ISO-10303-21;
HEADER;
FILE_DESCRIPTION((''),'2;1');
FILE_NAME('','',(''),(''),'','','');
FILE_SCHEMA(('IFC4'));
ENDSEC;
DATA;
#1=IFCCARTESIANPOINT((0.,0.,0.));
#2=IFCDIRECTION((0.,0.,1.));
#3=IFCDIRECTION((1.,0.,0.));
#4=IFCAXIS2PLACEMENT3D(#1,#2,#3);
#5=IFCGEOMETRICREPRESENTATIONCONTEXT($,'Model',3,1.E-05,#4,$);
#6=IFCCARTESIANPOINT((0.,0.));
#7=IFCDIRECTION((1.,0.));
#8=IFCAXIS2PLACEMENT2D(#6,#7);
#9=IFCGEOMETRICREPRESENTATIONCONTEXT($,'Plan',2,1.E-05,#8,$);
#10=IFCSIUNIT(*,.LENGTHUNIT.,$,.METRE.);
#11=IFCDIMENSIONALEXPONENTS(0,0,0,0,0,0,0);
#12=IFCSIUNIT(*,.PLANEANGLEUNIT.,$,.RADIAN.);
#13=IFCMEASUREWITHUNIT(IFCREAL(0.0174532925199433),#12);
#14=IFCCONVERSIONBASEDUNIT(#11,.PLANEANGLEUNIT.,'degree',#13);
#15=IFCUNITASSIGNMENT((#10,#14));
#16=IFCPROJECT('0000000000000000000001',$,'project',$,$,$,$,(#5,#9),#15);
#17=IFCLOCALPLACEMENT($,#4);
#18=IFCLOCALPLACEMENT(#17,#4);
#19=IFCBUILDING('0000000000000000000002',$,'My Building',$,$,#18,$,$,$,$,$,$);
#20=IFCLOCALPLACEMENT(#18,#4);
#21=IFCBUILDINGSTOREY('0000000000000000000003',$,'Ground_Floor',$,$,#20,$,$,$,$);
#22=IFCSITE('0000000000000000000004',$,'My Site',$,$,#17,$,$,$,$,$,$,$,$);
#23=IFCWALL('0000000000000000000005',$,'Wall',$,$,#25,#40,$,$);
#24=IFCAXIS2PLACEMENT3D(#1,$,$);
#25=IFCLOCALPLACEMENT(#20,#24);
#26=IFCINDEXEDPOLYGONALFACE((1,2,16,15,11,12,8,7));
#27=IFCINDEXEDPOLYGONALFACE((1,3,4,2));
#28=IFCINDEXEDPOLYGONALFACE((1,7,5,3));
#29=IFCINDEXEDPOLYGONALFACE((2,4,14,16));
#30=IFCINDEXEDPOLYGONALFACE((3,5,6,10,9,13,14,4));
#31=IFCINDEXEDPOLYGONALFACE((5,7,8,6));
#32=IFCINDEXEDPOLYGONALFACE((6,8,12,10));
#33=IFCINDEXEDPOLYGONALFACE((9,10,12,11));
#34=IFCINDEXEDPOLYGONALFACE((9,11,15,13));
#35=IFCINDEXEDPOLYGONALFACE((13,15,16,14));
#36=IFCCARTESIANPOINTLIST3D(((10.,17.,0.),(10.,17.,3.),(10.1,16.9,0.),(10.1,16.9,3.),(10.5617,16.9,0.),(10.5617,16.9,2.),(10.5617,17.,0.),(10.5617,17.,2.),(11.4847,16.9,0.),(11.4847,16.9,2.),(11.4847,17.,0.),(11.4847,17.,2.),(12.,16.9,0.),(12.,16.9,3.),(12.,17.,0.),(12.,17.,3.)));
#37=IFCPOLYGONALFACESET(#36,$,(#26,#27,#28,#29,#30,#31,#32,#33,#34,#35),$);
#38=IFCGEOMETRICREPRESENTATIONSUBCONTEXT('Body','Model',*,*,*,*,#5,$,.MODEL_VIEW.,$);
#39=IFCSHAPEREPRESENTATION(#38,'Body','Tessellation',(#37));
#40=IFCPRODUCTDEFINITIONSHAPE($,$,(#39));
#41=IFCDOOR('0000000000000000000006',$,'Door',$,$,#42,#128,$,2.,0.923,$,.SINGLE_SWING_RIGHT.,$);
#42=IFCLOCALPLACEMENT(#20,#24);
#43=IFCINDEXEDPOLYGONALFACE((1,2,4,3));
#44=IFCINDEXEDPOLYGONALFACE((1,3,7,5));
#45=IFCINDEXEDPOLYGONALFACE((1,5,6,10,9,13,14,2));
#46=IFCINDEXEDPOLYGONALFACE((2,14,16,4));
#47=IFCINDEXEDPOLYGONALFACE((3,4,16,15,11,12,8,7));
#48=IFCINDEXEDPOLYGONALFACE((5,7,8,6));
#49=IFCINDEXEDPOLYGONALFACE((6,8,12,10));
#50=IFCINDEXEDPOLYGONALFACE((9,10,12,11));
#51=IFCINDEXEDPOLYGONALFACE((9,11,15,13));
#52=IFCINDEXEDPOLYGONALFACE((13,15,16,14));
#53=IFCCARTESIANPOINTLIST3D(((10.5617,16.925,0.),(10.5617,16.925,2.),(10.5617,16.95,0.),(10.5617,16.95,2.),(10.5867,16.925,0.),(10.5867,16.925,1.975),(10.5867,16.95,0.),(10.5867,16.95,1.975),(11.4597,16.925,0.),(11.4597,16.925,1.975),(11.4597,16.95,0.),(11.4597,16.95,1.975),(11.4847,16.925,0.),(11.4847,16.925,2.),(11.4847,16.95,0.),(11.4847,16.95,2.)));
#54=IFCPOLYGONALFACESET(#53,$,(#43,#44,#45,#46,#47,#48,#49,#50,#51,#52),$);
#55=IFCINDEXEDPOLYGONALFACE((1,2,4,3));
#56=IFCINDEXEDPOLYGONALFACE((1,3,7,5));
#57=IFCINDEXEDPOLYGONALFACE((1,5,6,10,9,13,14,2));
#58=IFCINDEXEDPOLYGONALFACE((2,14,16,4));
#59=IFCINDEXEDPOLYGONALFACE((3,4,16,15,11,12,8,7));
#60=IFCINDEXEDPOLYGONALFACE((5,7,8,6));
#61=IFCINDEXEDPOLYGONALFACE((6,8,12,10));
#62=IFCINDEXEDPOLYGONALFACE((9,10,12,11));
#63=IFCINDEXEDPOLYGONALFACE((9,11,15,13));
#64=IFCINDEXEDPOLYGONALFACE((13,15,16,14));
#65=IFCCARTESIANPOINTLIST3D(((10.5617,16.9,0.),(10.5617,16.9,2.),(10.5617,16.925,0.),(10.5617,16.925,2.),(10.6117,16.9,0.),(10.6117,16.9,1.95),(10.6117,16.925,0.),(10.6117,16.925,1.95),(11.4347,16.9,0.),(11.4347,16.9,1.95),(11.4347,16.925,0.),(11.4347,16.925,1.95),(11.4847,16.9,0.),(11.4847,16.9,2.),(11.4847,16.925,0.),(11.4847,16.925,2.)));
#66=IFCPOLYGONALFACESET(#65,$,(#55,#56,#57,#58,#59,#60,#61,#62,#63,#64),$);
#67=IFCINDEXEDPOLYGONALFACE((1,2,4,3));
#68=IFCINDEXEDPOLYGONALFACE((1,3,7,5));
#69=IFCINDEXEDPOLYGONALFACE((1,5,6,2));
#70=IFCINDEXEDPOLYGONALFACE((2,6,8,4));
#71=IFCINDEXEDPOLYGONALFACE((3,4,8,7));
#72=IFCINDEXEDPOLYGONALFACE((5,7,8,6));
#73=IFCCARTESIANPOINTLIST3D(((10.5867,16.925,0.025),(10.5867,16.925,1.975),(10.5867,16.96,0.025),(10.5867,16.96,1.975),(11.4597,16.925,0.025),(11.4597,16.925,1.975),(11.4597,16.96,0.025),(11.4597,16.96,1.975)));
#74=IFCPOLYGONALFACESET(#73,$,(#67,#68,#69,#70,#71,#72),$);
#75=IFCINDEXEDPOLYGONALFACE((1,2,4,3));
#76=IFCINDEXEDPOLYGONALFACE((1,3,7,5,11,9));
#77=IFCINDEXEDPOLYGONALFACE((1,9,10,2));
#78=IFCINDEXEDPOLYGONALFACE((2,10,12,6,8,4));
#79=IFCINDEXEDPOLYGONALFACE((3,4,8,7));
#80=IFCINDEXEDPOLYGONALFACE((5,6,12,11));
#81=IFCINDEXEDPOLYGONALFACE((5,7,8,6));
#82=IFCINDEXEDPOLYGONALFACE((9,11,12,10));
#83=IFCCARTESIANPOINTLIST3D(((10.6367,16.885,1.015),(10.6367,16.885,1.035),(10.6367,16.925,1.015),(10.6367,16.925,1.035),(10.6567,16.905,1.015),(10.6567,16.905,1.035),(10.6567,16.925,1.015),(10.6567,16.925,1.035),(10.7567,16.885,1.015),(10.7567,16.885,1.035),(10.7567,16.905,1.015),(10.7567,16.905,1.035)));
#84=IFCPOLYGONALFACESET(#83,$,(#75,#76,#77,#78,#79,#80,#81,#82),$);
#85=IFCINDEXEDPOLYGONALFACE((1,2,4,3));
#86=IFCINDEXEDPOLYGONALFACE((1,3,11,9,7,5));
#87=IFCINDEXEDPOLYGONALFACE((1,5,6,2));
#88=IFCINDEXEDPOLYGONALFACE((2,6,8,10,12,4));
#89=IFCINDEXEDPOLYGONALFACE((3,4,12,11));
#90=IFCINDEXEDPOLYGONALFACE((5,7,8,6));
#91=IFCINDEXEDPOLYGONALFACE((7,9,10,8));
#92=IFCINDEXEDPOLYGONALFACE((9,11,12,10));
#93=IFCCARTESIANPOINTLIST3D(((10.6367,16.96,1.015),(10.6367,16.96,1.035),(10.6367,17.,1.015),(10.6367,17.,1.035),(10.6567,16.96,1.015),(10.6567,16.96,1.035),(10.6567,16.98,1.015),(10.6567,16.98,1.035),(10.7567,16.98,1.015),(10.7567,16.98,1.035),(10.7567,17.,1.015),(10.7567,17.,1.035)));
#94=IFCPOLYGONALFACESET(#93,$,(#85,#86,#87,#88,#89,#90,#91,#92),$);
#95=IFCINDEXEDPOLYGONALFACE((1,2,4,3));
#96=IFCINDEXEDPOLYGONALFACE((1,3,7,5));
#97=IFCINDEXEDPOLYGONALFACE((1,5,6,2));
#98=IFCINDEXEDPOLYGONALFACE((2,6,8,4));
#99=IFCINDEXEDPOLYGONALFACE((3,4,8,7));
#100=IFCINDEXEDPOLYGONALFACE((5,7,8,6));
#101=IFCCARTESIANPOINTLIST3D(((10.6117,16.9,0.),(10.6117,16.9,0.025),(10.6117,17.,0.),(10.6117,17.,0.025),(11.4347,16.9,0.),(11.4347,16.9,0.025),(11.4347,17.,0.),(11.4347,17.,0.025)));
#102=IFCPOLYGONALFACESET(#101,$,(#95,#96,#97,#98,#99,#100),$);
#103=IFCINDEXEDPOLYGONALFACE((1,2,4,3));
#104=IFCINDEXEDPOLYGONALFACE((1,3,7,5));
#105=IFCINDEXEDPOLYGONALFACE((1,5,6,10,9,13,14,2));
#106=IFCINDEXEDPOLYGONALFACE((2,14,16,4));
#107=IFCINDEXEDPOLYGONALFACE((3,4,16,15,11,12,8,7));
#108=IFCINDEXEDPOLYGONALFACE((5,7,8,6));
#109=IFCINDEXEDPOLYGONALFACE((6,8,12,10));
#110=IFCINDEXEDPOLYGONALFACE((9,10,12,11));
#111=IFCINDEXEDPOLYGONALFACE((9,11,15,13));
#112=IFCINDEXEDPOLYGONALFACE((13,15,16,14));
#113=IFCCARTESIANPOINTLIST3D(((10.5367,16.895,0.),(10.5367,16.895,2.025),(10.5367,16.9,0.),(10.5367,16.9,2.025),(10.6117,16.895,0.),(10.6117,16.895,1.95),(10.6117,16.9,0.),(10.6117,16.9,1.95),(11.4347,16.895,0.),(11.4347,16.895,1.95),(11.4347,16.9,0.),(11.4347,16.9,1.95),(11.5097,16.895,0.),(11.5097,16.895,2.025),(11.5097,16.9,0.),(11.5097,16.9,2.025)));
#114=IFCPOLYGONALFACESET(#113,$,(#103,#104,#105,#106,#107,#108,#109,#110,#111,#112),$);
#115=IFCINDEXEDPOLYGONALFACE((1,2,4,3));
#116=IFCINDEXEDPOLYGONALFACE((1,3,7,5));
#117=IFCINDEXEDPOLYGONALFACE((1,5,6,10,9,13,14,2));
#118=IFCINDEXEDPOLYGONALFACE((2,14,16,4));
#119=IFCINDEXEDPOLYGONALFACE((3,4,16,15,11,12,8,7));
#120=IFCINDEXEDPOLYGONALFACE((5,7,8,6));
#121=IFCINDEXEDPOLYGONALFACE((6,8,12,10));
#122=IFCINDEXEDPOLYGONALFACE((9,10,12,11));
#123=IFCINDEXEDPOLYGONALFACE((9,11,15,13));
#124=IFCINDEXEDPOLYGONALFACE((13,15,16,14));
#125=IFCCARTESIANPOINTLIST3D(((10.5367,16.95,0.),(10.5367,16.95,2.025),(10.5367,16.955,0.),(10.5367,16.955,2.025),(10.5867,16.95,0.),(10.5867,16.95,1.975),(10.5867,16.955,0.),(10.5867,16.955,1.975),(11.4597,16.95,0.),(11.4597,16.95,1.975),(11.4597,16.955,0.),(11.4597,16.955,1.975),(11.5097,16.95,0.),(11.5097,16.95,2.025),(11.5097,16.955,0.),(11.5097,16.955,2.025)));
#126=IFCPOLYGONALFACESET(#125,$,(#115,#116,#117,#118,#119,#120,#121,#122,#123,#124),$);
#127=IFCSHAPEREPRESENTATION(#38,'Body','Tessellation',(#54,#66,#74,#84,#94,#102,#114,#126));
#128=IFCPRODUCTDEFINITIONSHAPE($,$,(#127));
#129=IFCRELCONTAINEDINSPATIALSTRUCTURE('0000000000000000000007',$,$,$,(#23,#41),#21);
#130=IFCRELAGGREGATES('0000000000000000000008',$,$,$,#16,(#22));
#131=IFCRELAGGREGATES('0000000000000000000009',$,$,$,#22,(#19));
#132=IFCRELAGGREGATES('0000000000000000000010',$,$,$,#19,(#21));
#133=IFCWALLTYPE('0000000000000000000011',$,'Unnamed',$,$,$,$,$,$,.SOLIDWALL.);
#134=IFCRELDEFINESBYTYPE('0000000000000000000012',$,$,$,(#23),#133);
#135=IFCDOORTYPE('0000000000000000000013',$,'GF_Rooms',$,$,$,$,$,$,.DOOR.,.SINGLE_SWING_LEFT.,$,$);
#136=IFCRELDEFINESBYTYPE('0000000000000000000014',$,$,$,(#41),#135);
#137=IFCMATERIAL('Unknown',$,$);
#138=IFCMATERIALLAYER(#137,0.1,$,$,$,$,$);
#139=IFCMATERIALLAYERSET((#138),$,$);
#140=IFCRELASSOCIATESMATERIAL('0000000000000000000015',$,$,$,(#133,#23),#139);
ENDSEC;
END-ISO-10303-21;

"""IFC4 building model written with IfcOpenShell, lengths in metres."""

from ifc_helpers import new_model, entity, si_unit, converted_unit, frame, origin_with_axes, origin_2d_with_axis, place, context, subcontext, project, spatial, line, indexed_curve, outline, extrude, shape, source, transform, mapped, material, layer, layer_set, layer_usage, type_object, type_shapes, element, fill, save


model = new_model("IFC4")

# Units and contexts
model_context = context("Model", 3, precision=1e-05, world=origin_with_axes())
plan_context = context("Plan", 2, precision=1e-05, world=origin_2d_with_axis())
body_context_1 = subcontext(model_context, "Body", "Model", "MODEL_VIEW")
body_context_2 = subcontext(plan_context, "Body", "Plan", "PLAN_VIEW")
ifc_project = project(units=[si_unit("LENGTHUNIT", "METRE"), converted_unit("PLANEANGLEUNIT", "degree", entity("IfcReal", 0.0174532925199433), si_unit("PLANEANGLEUNIT", "RADIAN"), dimensions=[0, 0, 0, 0, 0, 0, 0])], contexts=[model_context, plan_context])

# Site, building, storey
site_placement = place(None, origin_with_axes())
site = spatial("IfcSite", under=ifc_project, at=site_placement, Name="My Site")
building_placement = place(site_placement, origin_with_axes())
building = spatial("IfcBuilding", under=site, at=building_placement, Name="My Building")
storey_placement = place(building_placement, origin_with_axes())
storey = spatial("IfcBuildingStorey", under=building, at=storey_placement, Name="Ground_Floor")

# Shared definitions
ifc_material = material(Name="Unknown")

# Shared definitions
ifc_layer_1 = layer(ifc_material, 0.1)
ifc_layer_set_1 = layer_set([ifc_layer_1])
wall_type = type_object("IfcWallType", Name="Unnamed", PredefinedType="SOLIDWALL", material=ifc_layer_set_1)
shared_shape_1 = source(origin_with_axes(), body_context_1, "Body", "SweptSolid", [
    extrude(outline(indexed_curve([(0.0, 0.0), (0.923, 0.0), (0.923, 2.0), (0.0, 2.0)], segments=[line(1, 2, 3, 4, 1)])), frame((0.0, -0.6, 0.0), z_axis=(0.0, -1.0, 0.0), x_axis=(1.0, 0.0, 0.0)), (0.0, 0.0, -1.0), 1.2),
])
door_type_1 = type_object("IfcDoorType", Name="GF_Rooms", OperationType="SINGLE_SWING_LEFT", PredefinedType="DOOR")
shared_shape_2 = source(origin_with_axes(), body_context_1, "Body", "SweptSolid", [
    extrude(outline(indexed_curve([(0.0, 0.0), (0.0, 2.0), (0.923, 2.0), (0.923, 0.0), (0.898, 0.0), (0.898, 1.975), (0.025, 1.975), (0.025, 0.0)], segments=[line(1, 2, 3, 4, 5, 6, 7, 8, 1)])), frame((0.0, 0.025, 0.0), z_axis=(0.0, -1.0, 0.0), x_axis=(1.0, 0.0, 0.0)), (0.0, 0.0, -1.0), 0.025),
    extrude(outline(indexed_curve([(0.0, 0.0), (0.0, 2.0), (0.923, 2.0), (0.923, 0.0), (0.873, 0.0), (0.873, 1.95), (0.05, 1.95), (0.05, 0.0)], segments=[line(1, 2, 3, 4, 5, 6, 7, 8, 1)])), frame((0.0, 0.0, 0.0), z_axis=(0.0, -1.0, 0.0), x_axis=(1.0, 0.0, 0.0)), (0.0, 0.0, -1.0), 0.025),
    extrude(outline(indexed_curve([(0.0, 0.0), (0.873, 0.0), (0.873, 0.035), (0.0, 0.035)], segments=[line(1, 2, 3, 4, 1)])), frame((0.025, 0.025, 0.025), z_axis=(0.0, 0.0, 1.0), x_axis=(1.0, 0.0, 0.0)), (0.0, 0.0, 1.0), 1.95),
    extrude(outline(indexed_curve([(0.0, 0.0), (0.0, -0.04), (0.12, -0.04), (0.12, -0.02), (0.02, -0.02), (0.02, 0.0)], segments=[line(1, 2, 3, 4, 5, 6, 1)])), frame((0.075, 0.025, 1.015), z_axis=(0.0, 0.0, 1.0), x_axis=(1.0, 0.0, 0.0)), (0.0, 0.0, 1.0), 0.02),
    extrude(outline(indexed_curve([(0.0, 0.0), (0.0, 0.04), (0.12, 0.04), (0.12, 0.02), (0.02, 0.02), (0.02, 0.0)], segments=[line(1, 2, 3, 4, 5, 6, 1)])), frame((0.075, 0.06, 1.015), z_axis=(0.0, 0.0, 1.0), x_axis=(1.0, 0.0, 0.0)), (0.0, 0.0, 1.0), 0.02),
    extrude(outline(indexed_curve([(0.0, 0.0), (0.823, 0.0), (0.823, 0.1), (0.0, 0.1)], segments=[line(1, 2, 3, 4, 1)])), frame((0.05, 0.0, 0.0), z_axis=(0.0, 0.0, 1.0), x_axis=(1.0, 0.0, 0.0)), (0.0, 0.0, 1.0), 0.025),
    extrude(outline(indexed_curve([(0.0, 0.0), (0.0, 2.025), (0.973, 2.025), (0.973, 0.0), (0.898, 0.0), (0.898, 1.95), (0.075, 1.95), (0.075, 0.0)], segments=[line(1, 2, 3, 4, 5, 6, 7, 8, 1)])), frame((-0.025, -0.005, 0.0), z_axis=(0.0, -1.0, 0.0), x_axis=(1.0, 0.0, 0.0)), (0.0, 0.0, -1.0), 0.005),
    extrude(outline(indexed_curve([(0.0, 0.0), (0.0, 2.025), (0.973, 2.025), (0.973, 0.0), (0.923, 0.0), (0.923, 1.975), (0.05, 1.975), (0.05, 0.0)], segments=[line(1, 2, 3, 4, 5, 6, 7, 8, 1)])), frame((-0.025, 0.05, 0.0), z_axis=(0.0, -1.0, 0.0), x_axis=(1.0, 0.0, 0.0)), (0.0, 0.0, -1.0), 0.005),
])
shared_shape_3 = source(origin_with_axes(), body_context_2, "Body", "Curve2D", [
    entity("IfcIndexedPolyCurve", entity("IfcCartesianPointList2D", [[0.0, 0.0], [0.0, 0.05], [0.025, 0.05], [0.025, 0.025], [0.05, 0.025], [0.05, 0.0]]), [entity("IfcLineIndex", [1, 2, 3, 4, 5, 6, 1])]),
    entity("IfcIndexedPolyCurve", entity("IfcCartesianPointList2D", [[0.923, 0.0], [0.923, 0.05], [0.898, 0.05], [0.898, 0.025], [0.873, 0.025], [0.873, 0.0]]), [entity("IfcLineIndex", [1, 2, 3, 4, 5, 6, 1])]),
    entity("IfcTrimmedCurve", entity("IfcEllipse", entity("IfcAxis2Placement2D", entity("IfcCartesianPoint", [0.863, 0.05]), entity("IfcDirection", [1.0, 0.0])), 0.838, 0.873), [entity("IfcCartesianPoint", [0.863, 0.923])], [entity("IfcCartesianPoint", [0.025, 0.05])], True, "CARTESIAN"),
    entity("IfcIndexedPolyCurve", entity("IfcCartesianPointList2D", [[0.898, 0.05], [0.863, 0.05], [0.863, 0.923], [0.898, 0.923]]), [entity("IfcLineIndex", [1, 2, 3, 4, 1])]),
])
type_shapes(door_type_1, [shared_shape_2, shared_shape_3])

# Wall, opening, door
ifc_layer_usage_1 = layer_usage(ifc_layer_set_1, "AXIS2", "POSITIVE", 0.0)
wall_1_placement = place(storey_placement, frame((12.0, 17.0, 0.0), z_axis=(0.0, 0.0, 1.0), x_axis=(-1.0, 0.0, 0.0)))
wall_1 = element("IfcWall", 1, at=wall_1_placement, inside=storey, type_object=wall_type, material=ifc_layer_usage_1, Name="Wall", context=body_context_1, shape_type="SweptSolid", body=[
    extrude(outline(indexed_curve([(0.0, 0.0), (0.0, 0.1), (1.9, 0.1), (2.0, 0.0)], segments=[line(1, 2, 3, 4, 1)])), origin_with_axes(), (0.0, 0.0, 1.0), 3.0),
])
opening_1_placement = place(wall_1_placement, frame((1.4383, 0.1, 0.0), z_axis=(0.0, 0.0, 1.0), x_axis=(-1.0, 0.0, 0.0)))
opening_1 = element("IfcOpeningElement", 2, at=opening_1_placement, cuts=wall_1, PredefinedType="OPENING", context=body_context_1, shape_type="MappedRepresentation", body=[
    mapped(shared_shape_1, transform((0.0, 0.0, 0.0), x_axis=(1.0, 0.0, 0.0), y_axis=(0.0, 1.0, 0.0), z_axis=(0.0, 0.0, 1.0), scale=1.0)),
])
door_1_placement = place(opening_1_placement, frame((0.0, 0.0, 0.0), z_axis=(0.0, 0.0, 1.0), x_axis=(1.0, 0.0, 0.0)))
door_1 = element("IfcDoor", 3, at=door_1_placement, inside=storey, type_object=door_type_1, Name="Door", OperationType="SINGLE_SWING_RIGHT", OverallHeight=2.0, OverallWidth=0.923, shapes=[
    shape(body_context_1, "Body", "MappedRepresentation", [mapped(shared_shape_2, transform((0.0, 0.0, 0.0), x_axis=(1.0, 0.0, 0.0), y_axis=(0.0, 1.0, 0.0), z_axis=(0.0, 0.0, 1.0), scale=1.0))]),
    shape(body_context_2, "Body", "MappedRepresentation", [mapped(shared_shape_3, transform((0.0, 0.0, 0.0), x_axis=(1.0, 0.0, 0.0), y_axis=(0.0, 1.0, 0.0), z_axis=(0.0, 0.0, 1.0), scale=1.0))]),
])
fill(opening_1, door_1)

save(model, "model.ifc")
